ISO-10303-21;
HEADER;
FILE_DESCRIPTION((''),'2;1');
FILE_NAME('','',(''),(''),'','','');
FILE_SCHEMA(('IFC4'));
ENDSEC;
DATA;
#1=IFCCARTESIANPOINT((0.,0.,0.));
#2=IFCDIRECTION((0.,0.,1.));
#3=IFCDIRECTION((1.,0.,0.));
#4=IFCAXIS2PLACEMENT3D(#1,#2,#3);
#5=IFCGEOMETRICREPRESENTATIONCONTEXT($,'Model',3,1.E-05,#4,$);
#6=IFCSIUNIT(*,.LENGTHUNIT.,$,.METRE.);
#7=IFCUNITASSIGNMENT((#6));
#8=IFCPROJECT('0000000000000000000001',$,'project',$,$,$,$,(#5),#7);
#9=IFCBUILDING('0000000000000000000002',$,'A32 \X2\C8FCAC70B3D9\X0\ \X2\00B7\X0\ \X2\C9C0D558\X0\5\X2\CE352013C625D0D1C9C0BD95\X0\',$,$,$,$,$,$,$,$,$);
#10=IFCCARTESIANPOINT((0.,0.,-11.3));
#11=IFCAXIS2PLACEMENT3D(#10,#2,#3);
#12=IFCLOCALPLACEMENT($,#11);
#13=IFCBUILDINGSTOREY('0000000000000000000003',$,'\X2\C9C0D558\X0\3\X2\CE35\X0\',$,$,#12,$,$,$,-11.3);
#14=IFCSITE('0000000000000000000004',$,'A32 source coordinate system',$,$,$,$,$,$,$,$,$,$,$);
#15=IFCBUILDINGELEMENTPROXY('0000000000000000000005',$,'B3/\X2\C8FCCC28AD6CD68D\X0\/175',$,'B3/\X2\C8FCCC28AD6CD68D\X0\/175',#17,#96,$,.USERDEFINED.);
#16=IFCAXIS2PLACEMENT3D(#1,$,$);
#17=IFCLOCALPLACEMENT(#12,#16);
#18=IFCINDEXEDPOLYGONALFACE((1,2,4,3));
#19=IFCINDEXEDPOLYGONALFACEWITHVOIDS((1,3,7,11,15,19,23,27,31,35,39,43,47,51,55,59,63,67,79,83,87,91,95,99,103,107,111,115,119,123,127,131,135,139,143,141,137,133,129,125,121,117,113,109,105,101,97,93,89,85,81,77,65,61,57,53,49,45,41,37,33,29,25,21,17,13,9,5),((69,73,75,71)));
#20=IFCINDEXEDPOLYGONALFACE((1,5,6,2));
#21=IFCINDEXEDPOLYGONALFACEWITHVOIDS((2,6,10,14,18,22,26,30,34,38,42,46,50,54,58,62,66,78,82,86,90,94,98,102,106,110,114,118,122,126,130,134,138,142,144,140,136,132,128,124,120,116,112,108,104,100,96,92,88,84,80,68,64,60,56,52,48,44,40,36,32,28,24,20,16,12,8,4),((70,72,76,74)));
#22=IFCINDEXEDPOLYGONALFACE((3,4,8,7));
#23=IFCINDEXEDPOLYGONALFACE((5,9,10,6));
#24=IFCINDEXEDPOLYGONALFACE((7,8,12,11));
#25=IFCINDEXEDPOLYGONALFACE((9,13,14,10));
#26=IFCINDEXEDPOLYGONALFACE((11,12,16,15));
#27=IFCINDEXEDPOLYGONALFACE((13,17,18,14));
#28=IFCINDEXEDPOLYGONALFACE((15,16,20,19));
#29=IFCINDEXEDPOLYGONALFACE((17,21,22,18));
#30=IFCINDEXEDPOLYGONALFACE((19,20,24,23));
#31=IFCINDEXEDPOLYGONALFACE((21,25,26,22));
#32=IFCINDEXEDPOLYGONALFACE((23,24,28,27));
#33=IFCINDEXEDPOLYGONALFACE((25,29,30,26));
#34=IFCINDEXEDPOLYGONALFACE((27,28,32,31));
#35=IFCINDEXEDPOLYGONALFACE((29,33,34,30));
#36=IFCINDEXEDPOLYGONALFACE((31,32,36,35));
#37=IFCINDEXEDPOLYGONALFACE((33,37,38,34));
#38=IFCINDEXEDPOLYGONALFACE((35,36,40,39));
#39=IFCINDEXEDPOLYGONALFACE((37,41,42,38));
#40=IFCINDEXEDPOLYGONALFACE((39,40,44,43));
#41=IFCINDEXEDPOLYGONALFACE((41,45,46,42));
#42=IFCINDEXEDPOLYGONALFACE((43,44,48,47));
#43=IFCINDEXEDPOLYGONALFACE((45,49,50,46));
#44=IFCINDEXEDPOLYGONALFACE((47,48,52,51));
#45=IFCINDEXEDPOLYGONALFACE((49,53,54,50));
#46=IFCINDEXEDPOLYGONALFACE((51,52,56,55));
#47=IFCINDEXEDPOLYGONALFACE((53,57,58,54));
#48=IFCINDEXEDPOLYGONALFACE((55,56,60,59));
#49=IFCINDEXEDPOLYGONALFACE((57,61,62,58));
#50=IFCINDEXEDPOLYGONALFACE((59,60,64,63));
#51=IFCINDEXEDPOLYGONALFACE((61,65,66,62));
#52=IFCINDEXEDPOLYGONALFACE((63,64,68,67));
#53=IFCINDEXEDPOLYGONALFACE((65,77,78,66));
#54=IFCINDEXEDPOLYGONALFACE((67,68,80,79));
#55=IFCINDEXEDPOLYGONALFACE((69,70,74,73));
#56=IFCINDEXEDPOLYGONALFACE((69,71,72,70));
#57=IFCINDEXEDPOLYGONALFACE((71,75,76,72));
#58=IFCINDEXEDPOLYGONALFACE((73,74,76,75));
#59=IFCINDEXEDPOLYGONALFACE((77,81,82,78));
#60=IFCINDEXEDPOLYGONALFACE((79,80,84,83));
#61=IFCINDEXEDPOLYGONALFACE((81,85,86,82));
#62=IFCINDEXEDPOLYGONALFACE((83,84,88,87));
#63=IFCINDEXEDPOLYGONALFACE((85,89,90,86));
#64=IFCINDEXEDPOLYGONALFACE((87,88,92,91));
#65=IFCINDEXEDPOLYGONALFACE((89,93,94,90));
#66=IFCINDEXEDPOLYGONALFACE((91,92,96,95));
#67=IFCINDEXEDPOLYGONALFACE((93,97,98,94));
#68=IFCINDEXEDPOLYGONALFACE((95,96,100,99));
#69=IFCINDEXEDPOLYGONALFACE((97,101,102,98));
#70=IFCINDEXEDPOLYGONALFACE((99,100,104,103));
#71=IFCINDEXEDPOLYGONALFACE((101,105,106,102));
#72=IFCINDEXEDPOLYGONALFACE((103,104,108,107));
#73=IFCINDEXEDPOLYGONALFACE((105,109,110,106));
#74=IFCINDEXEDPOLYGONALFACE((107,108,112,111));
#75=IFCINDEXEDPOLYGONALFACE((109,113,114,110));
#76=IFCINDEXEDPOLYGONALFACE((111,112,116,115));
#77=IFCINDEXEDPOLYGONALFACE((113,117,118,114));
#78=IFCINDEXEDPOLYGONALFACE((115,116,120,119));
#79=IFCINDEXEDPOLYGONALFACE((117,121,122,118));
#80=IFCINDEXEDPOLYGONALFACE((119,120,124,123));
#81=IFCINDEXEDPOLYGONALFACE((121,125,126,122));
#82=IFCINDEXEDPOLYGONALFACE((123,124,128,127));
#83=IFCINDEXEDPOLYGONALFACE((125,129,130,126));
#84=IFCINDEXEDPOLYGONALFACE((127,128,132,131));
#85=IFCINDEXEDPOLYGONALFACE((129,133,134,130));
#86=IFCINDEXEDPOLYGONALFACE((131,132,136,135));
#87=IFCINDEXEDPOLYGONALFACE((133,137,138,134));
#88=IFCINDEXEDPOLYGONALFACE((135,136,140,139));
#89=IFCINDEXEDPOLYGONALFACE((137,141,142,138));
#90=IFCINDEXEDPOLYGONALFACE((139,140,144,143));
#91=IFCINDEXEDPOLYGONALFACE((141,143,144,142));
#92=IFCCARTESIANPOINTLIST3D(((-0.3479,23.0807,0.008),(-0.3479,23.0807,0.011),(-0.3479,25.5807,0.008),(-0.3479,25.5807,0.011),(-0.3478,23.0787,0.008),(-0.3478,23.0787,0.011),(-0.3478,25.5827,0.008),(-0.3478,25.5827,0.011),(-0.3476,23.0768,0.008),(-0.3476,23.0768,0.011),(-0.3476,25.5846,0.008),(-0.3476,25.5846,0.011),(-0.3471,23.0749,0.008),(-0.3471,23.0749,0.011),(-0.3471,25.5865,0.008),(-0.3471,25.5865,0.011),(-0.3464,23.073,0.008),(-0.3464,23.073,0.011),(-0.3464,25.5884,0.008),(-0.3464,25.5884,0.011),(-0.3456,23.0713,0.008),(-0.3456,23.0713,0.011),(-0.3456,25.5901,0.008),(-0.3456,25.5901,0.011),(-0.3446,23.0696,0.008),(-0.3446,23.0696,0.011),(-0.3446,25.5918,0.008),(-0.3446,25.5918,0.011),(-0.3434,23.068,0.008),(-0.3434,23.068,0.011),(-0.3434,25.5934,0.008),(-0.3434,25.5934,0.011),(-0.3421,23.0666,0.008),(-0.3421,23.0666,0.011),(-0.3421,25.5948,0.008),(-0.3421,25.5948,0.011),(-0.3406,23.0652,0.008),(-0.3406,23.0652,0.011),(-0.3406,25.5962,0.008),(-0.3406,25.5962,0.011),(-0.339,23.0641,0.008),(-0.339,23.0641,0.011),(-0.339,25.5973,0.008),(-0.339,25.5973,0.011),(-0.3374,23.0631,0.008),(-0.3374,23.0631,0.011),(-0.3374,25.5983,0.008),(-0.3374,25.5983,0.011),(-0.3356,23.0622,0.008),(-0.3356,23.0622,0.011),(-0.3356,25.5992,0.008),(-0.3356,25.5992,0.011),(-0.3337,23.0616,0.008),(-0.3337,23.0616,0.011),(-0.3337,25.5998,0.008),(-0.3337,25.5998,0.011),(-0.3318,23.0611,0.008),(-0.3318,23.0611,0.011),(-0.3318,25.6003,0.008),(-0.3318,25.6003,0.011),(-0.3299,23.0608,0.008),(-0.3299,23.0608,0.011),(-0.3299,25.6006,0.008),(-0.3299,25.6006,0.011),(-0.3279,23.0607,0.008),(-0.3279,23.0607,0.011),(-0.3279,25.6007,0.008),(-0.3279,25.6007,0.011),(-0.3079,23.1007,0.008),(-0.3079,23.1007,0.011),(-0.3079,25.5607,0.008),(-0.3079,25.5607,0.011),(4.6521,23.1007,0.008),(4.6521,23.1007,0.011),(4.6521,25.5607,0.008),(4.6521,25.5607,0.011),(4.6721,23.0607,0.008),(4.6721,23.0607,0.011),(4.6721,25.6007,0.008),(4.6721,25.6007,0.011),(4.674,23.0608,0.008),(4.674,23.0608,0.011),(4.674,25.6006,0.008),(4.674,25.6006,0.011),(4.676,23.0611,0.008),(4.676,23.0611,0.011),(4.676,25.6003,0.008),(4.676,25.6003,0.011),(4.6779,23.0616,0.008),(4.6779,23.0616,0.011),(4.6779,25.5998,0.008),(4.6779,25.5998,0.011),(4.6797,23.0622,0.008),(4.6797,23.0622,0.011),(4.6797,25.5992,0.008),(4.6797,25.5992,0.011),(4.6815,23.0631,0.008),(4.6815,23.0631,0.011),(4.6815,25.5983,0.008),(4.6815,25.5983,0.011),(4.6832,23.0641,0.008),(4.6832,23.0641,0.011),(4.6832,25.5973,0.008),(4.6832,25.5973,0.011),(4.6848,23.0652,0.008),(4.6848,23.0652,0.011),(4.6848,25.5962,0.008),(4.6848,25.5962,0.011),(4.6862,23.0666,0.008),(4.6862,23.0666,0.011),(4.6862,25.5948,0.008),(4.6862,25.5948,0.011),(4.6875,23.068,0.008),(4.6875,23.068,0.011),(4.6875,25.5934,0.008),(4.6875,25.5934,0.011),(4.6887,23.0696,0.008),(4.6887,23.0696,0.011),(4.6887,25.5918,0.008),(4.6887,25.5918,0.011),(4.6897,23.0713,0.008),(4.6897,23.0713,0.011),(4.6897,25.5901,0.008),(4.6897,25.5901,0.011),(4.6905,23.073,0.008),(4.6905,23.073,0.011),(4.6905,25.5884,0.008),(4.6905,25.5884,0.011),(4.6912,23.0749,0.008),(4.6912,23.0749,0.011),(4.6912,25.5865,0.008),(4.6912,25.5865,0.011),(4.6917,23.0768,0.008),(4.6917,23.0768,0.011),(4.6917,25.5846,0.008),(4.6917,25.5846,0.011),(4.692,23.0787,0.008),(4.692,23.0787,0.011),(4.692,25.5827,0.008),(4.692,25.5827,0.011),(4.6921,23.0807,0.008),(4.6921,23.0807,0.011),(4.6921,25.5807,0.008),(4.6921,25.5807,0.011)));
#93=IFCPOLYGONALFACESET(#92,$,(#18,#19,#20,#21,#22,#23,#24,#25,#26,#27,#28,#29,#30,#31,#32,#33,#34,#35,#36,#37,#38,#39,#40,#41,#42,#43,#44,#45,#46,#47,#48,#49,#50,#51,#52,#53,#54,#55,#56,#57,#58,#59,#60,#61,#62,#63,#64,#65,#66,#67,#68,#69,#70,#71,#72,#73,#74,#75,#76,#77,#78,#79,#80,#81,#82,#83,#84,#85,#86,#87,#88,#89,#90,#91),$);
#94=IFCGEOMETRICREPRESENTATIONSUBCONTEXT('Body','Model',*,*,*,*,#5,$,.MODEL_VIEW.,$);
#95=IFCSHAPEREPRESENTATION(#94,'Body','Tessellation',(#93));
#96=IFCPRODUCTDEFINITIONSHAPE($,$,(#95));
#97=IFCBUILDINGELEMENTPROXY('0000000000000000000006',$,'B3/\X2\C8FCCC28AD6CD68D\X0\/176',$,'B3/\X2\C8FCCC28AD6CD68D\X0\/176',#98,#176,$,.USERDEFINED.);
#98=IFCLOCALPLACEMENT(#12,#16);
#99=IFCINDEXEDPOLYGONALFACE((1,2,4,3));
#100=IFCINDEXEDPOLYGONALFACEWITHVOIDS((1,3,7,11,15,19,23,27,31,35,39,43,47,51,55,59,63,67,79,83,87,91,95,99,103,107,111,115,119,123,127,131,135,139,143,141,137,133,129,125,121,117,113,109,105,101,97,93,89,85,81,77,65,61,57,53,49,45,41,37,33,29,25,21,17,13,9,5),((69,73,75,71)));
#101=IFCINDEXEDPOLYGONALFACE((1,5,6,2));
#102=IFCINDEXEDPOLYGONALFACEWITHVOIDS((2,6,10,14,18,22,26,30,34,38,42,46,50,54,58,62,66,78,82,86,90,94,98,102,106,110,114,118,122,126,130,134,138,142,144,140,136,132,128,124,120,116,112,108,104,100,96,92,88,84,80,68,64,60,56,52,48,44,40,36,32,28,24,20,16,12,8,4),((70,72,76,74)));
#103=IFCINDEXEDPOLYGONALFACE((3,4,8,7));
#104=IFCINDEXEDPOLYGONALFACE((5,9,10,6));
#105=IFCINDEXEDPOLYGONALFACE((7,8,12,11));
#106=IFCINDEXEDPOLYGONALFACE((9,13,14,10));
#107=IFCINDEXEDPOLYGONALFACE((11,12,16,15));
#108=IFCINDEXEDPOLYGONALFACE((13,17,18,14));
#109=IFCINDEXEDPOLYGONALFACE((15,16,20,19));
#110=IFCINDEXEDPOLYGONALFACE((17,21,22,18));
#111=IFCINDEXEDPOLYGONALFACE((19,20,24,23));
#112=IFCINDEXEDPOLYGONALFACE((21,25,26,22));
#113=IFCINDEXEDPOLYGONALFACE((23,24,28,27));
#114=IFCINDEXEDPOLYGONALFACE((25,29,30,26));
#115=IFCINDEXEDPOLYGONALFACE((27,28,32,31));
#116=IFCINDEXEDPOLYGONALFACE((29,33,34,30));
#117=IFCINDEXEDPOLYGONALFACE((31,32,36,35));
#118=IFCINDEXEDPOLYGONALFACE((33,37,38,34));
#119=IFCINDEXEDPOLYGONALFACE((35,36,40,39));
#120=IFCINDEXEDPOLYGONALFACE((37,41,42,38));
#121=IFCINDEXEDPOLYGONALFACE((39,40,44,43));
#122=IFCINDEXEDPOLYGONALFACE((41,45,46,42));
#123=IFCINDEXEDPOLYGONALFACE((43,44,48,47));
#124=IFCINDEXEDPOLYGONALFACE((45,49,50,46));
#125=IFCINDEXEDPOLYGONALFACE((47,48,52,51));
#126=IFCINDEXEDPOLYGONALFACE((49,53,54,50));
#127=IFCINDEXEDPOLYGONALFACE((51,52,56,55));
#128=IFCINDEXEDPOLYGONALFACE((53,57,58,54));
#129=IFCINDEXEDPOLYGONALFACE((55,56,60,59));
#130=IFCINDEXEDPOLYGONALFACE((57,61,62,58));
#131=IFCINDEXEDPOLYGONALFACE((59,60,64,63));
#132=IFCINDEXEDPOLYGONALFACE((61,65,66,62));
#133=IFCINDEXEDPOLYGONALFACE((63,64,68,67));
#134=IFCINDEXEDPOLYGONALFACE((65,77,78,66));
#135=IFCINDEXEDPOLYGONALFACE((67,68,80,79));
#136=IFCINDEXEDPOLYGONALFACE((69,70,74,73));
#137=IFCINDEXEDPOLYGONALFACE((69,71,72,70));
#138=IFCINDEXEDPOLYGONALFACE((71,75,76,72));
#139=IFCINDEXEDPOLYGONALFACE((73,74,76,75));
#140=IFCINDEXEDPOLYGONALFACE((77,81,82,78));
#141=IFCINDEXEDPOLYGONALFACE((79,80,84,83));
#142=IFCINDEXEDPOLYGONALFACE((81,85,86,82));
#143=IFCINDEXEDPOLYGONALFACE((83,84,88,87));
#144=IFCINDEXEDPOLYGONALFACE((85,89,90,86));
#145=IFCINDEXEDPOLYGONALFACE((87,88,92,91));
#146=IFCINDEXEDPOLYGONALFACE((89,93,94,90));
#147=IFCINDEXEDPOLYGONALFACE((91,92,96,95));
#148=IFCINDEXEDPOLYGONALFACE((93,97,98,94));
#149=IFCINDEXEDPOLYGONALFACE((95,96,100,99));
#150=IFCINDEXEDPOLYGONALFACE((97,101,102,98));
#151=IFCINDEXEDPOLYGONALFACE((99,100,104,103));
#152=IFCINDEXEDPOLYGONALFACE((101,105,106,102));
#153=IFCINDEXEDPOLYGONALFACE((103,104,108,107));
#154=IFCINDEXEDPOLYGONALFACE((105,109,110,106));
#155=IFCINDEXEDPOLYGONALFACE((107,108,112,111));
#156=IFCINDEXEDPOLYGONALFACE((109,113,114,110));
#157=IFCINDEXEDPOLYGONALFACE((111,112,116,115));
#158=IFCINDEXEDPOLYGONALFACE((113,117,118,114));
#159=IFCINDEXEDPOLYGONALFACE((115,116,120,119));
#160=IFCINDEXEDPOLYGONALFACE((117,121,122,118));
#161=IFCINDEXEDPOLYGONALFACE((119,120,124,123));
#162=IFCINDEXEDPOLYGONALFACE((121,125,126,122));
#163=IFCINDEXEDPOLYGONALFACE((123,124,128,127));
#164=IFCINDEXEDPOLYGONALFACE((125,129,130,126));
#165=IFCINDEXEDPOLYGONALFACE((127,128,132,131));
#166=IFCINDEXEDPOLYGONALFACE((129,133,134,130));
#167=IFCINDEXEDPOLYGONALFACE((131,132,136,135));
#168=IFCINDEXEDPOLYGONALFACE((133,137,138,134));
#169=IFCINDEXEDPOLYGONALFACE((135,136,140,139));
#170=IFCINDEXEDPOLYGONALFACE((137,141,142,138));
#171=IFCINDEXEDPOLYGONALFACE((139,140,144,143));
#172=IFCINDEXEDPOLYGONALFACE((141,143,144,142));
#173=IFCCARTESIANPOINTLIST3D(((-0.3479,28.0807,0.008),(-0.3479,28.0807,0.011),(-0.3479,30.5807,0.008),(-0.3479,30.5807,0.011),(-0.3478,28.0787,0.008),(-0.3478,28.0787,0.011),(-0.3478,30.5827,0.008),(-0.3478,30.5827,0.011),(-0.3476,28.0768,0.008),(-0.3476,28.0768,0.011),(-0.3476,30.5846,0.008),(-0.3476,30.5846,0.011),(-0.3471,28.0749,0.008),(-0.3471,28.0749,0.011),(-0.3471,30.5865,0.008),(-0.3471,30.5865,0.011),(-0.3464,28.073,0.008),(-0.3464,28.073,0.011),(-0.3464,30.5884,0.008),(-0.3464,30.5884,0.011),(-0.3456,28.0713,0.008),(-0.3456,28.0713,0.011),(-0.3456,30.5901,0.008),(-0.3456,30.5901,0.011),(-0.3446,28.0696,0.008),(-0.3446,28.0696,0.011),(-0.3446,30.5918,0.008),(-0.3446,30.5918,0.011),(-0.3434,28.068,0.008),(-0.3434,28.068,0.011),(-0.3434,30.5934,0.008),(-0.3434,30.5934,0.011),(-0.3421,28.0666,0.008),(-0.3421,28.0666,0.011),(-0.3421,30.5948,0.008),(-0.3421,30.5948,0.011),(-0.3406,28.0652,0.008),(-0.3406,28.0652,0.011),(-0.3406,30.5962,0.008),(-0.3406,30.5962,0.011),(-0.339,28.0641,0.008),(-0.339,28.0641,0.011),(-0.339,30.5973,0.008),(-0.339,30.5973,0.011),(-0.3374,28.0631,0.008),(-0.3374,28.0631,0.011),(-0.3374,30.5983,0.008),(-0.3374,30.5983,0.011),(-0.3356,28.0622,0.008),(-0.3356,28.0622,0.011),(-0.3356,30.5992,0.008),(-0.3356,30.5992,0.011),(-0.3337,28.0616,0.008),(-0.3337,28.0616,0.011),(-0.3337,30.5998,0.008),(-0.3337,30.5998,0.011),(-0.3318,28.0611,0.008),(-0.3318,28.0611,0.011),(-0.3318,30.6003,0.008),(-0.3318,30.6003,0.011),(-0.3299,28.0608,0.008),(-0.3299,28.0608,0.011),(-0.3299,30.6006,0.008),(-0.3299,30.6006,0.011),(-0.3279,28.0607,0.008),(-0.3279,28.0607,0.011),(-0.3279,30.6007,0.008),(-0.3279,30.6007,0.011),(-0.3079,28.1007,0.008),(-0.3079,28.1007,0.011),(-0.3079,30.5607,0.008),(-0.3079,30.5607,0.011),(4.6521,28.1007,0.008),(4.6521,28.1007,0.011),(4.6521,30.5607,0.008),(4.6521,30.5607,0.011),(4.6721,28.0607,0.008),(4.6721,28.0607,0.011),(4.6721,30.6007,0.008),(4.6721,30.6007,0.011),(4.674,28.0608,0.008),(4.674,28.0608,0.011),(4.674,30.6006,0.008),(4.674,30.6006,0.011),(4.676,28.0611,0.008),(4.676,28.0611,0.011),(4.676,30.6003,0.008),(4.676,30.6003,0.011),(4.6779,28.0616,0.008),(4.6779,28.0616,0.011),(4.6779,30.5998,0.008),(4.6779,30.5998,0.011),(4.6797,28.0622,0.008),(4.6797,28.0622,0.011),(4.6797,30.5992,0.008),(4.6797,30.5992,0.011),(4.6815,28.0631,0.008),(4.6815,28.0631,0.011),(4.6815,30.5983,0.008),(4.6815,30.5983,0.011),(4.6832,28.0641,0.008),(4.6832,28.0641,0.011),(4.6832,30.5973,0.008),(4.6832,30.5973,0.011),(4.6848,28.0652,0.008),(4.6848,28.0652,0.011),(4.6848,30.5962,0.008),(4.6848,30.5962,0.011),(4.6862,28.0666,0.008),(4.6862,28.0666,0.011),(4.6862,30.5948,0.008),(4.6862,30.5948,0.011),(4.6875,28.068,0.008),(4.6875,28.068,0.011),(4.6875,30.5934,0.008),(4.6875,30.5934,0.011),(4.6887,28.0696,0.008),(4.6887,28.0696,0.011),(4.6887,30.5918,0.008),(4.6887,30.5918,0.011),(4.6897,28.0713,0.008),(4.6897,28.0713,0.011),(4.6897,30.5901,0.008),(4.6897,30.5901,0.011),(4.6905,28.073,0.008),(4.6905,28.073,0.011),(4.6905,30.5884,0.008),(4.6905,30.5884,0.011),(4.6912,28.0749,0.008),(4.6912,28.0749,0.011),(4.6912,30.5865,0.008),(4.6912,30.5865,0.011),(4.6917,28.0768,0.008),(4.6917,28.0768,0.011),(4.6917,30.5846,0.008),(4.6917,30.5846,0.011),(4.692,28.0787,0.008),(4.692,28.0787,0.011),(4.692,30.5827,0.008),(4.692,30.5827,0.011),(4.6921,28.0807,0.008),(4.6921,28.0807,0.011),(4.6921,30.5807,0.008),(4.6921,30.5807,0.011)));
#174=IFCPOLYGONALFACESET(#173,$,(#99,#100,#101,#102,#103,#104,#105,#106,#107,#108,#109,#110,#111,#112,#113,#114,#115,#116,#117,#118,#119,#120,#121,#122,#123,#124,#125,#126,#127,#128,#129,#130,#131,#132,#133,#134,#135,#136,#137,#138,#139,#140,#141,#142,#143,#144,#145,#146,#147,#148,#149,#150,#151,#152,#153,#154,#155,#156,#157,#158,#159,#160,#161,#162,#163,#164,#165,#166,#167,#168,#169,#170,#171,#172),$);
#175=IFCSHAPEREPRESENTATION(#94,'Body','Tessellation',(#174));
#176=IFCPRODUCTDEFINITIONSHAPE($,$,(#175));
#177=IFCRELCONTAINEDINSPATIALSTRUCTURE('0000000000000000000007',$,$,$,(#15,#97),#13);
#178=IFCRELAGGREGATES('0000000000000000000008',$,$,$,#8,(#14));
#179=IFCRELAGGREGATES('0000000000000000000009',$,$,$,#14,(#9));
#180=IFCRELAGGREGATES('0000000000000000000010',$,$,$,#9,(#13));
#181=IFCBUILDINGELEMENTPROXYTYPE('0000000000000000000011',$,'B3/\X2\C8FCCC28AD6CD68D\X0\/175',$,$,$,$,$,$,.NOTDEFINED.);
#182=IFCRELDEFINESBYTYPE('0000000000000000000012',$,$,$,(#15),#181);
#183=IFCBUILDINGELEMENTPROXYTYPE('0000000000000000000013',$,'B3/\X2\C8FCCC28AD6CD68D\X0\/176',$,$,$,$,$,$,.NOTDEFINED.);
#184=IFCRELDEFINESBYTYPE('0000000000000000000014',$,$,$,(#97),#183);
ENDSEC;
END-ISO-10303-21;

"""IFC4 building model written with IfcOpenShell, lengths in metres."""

from ifc_helpers import new_model, si_unit, frame, origin, origin_with_axes, place, context, subcontext, project, spatial, polyline, outline, extrude, source, transform, mapped, type_object, type_shapes, element, save


model = new_model("IFC4")

# Units and contexts
model_context = context("Model", 3, precision=1e-05, world=origin_with_axes())
body_context = subcontext(model_context, "Body", "Model", "MODEL_VIEW")
ifc_project = project(units=[si_unit("LENGTHUNIT", "METRE")], contexts=[model_context])

# Site, building, storey
site = spatial("IfcSite", under=ifc_project, Name="A32 source coordinate system")
building = spatial("IfcBuilding", under=site, Name="A32 주거동 · 지하5층–옥탑지붕")
storey_placement = place(None, frame((0.0, 0.0, -11.3), z_axis=(0.0, 0.0, 1.0), x_axis=(1.0, 0.0, 0.0)))
storey = spatial("IfcBuildingStorey", under=building, at=storey_placement, Name="지하3층", Elevation=-11.3)

# Building element proxies
building_element_proxy_type_1 = type_object("IfcBuildingElementProxyType", Name="B3/주차구획/175", PredefinedType="NOTDEFINED")
shared_shape_1 = source(origin(), body_context, "Body", "SweptSolid", [
    extrude(outline(polyline([(-0.3279, 23.0607), (-0.3299, 23.0608), (-0.3318, 23.0611), (-0.3337, 23.0616), (-0.3356, 23.0622), (-0.3374, 23.0631), (-0.339, 23.0641), (-0.3406, 23.0652), (-0.3421, 23.0666), (-0.3434, 23.068), (-0.3446, 23.0696), (-0.3456, 23.0713), (-0.3464, 23.073), (-0.3471, 23.0749), (-0.3476, 23.0768), (-0.3478, 23.0787), (-0.3479, 23.0807), (-0.3479, 25.5807), (-0.3478, 25.5827), (-0.3476, 25.5846), (-0.3471, 25.5865), (-0.3464, 25.5884), (-0.3456, 25.5901), (-0.3446, 25.5918), (-0.3434, 25.5934), (-0.3421, 25.5948), (-0.3406, 25.5962), (-0.339, 25.5973), (-0.3374, 25.5983), (-0.3356, 25.5992), (-0.3337, 25.5998), (-0.3318, 25.6003), (-0.3299, 25.6006), (-0.3279, 25.6007), (4.6721, 25.6007), (4.674, 25.6006), (4.676, 25.6003), (4.6779, 25.5998), (4.6797, 25.5992), (4.6815, 25.5983), (4.6832, 25.5973), (4.6848, 25.5962), (4.6862, 25.5948), (4.6875, 25.5934), (4.6887, 25.5918), (4.6897, 25.5901), (4.6905, 25.5884), (4.6912, 25.5865), (4.6917, 25.5846), (4.692, 25.5827), (4.6921, 25.5807), (4.6921, 23.0807), (4.692, 23.0787), (4.6917, 23.0768), (4.6912, 23.0749), (4.6905, 23.073), (4.6897, 23.0713), (4.6887, 23.0696), (4.6875, 23.068), (4.6862, 23.0666), (4.6848, 23.0652), (4.6832, 23.0641), (4.6815, 23.0631), (4.6797, 23.0622), (4.6779, 23.0616), (4.676, 23.0611), (4.674, 23.0608), (4.6721, 23.0607), (-0.3279, 23.0607)]), holes=[polyline([(-0.3079, 23.1007), (4.6521, 23.1007), (4.6521, 25.5607), (-0.3079, 25.5607), (-0.3079, 23.1007)])]), frame((0.0, 0.0, 0.008)), (0.0, 0.0, 1.0), 0.003),
])
type_shapes(building_element_proxy_type_1, [shared_shape_1])
proxy_1_placement = place(storey_placement, origin_with_axes())
element("IfcBuildingElementProxy", 1, at=proxy_1_placement, inside=storey, type_object=building_element_proxy_type_1, Name="B3/주차구획/175", ObjectType="B3/주차구획/175", PredefinedType="USERDEFINED", context=body_context, shape_type="MappedRepresentation", body=[
    mapped(shared_shape_1, transform((0.0, 0.0, 0.0), scale=1.0)),
])
building_element_proxy_type_2 = type_object("IfcBuildingElementProxyType", Name="B3/주차구획/176", PredefinedType="NOTDEFINED")
shared_shape_2 = source(origin(), body_context, "Body", "SweptSolid", [
    extrude(outline(polyline([(-0.3279, 28.0607), (-0.3299, 28.0608), (-0.3318, 28.0611), (-0.3337, 28.0616), (-0.3356, 28.0622), (-0.3374, 28.0631), (-0.339, 28.0641), (-0.3406, 28.0652), (-0.3421, 28.0666), (-0.3434, 28.068), (-0.3446, 28.0696), (-0.3456, 28.0713), (-0.3464, 28.073), (-0.3471, 28.0749), (-0.3476, 28.0768), (-0.3478, 28.0787), (-0.3479, 28.0807), (-0.3479, 30.5807), (-0.3478, 30.5827), (-0.3476, 30.5846), (-0.3471, 30.5865), (-0.3464, 30.5884), (-0.3456, 30.5901), (-0.3446, 30.5918), (-0.3434, 30.5934), (-0.3421, 30.5948), (-0.3406, 30.5962), (-0.339, 30.5973), (-0.3374, 30.5983), (-0.3356, 30.5992), (-0.3337, 30.5998), (-0.3318, 30.6003), (-0.3299, 30.6006), (-0.3279, 30.6007), (4.6721, 30.6007), (4.674, 30.6006), (4.676, 30.6003), (4.6779, 30.5998), (4.6797, 30.5992), (4.6815, 30.5983), (4.6832, 30.5973), (4.6848, 30.5962), (4.6862, 30.5948), (4.6875, 30.5934), (4.6887, 30.5918), (4.6897, 30.5901), (4.6905, 30.5884), (4.6912, 30.5865), (4.6917, 30.5846), (4.692, 30.5827), (4.6921, 30.5807), (4.6921, 28.0807), (4.692, 28.0787), (4.6917, 28.0768), (4.6912, 28.0749), (4.6905, 28.073), (4.6897, 28.0713), (4.6887, 28.0696), (4.6875, 28.068), (4.6862, 28.0666), (4.6848, 28.0652), (4.6832, 28.0641), (4.6815, 28.0631), (4.6797, 28.0622), (4.6779, 28.0616), (4.676, 28.0611), (4.674, 28.0608), (4.6721, 28.0607), (-0.3279, 28.0607)]), holes=[polyline([(-0.3079, 28.1007), (4.6521, 28.1007), (4.6521, 30.5607), (-0.3079, 30.5607), (-0.3079, 28.1007)])]), frame((0.0, 0.0, 0.008)), (0.0, 0.0, 1.0), 0.003),
])
type_shapes(building_element_proxy_type_2, [shared_shape_2])
proxy_2_placement = place(storey_placement, origin_with_axes())
element("IfcBuildingElementProxy", 2, at=proxy_2_placement, inside=storey, type_object=building_element_proxy_type_2, Name="B3/주차구획/176", ObjectType="B3/주차구획/176", PredefinedType="USERDEFINED", context=body_context, shape_type="MappedRepresentation", body=[
    mapped(shared_shape_2, transform((0.0, 0.0, 0.0), scale=1.0)),
])

save(model, "model.ifc")
